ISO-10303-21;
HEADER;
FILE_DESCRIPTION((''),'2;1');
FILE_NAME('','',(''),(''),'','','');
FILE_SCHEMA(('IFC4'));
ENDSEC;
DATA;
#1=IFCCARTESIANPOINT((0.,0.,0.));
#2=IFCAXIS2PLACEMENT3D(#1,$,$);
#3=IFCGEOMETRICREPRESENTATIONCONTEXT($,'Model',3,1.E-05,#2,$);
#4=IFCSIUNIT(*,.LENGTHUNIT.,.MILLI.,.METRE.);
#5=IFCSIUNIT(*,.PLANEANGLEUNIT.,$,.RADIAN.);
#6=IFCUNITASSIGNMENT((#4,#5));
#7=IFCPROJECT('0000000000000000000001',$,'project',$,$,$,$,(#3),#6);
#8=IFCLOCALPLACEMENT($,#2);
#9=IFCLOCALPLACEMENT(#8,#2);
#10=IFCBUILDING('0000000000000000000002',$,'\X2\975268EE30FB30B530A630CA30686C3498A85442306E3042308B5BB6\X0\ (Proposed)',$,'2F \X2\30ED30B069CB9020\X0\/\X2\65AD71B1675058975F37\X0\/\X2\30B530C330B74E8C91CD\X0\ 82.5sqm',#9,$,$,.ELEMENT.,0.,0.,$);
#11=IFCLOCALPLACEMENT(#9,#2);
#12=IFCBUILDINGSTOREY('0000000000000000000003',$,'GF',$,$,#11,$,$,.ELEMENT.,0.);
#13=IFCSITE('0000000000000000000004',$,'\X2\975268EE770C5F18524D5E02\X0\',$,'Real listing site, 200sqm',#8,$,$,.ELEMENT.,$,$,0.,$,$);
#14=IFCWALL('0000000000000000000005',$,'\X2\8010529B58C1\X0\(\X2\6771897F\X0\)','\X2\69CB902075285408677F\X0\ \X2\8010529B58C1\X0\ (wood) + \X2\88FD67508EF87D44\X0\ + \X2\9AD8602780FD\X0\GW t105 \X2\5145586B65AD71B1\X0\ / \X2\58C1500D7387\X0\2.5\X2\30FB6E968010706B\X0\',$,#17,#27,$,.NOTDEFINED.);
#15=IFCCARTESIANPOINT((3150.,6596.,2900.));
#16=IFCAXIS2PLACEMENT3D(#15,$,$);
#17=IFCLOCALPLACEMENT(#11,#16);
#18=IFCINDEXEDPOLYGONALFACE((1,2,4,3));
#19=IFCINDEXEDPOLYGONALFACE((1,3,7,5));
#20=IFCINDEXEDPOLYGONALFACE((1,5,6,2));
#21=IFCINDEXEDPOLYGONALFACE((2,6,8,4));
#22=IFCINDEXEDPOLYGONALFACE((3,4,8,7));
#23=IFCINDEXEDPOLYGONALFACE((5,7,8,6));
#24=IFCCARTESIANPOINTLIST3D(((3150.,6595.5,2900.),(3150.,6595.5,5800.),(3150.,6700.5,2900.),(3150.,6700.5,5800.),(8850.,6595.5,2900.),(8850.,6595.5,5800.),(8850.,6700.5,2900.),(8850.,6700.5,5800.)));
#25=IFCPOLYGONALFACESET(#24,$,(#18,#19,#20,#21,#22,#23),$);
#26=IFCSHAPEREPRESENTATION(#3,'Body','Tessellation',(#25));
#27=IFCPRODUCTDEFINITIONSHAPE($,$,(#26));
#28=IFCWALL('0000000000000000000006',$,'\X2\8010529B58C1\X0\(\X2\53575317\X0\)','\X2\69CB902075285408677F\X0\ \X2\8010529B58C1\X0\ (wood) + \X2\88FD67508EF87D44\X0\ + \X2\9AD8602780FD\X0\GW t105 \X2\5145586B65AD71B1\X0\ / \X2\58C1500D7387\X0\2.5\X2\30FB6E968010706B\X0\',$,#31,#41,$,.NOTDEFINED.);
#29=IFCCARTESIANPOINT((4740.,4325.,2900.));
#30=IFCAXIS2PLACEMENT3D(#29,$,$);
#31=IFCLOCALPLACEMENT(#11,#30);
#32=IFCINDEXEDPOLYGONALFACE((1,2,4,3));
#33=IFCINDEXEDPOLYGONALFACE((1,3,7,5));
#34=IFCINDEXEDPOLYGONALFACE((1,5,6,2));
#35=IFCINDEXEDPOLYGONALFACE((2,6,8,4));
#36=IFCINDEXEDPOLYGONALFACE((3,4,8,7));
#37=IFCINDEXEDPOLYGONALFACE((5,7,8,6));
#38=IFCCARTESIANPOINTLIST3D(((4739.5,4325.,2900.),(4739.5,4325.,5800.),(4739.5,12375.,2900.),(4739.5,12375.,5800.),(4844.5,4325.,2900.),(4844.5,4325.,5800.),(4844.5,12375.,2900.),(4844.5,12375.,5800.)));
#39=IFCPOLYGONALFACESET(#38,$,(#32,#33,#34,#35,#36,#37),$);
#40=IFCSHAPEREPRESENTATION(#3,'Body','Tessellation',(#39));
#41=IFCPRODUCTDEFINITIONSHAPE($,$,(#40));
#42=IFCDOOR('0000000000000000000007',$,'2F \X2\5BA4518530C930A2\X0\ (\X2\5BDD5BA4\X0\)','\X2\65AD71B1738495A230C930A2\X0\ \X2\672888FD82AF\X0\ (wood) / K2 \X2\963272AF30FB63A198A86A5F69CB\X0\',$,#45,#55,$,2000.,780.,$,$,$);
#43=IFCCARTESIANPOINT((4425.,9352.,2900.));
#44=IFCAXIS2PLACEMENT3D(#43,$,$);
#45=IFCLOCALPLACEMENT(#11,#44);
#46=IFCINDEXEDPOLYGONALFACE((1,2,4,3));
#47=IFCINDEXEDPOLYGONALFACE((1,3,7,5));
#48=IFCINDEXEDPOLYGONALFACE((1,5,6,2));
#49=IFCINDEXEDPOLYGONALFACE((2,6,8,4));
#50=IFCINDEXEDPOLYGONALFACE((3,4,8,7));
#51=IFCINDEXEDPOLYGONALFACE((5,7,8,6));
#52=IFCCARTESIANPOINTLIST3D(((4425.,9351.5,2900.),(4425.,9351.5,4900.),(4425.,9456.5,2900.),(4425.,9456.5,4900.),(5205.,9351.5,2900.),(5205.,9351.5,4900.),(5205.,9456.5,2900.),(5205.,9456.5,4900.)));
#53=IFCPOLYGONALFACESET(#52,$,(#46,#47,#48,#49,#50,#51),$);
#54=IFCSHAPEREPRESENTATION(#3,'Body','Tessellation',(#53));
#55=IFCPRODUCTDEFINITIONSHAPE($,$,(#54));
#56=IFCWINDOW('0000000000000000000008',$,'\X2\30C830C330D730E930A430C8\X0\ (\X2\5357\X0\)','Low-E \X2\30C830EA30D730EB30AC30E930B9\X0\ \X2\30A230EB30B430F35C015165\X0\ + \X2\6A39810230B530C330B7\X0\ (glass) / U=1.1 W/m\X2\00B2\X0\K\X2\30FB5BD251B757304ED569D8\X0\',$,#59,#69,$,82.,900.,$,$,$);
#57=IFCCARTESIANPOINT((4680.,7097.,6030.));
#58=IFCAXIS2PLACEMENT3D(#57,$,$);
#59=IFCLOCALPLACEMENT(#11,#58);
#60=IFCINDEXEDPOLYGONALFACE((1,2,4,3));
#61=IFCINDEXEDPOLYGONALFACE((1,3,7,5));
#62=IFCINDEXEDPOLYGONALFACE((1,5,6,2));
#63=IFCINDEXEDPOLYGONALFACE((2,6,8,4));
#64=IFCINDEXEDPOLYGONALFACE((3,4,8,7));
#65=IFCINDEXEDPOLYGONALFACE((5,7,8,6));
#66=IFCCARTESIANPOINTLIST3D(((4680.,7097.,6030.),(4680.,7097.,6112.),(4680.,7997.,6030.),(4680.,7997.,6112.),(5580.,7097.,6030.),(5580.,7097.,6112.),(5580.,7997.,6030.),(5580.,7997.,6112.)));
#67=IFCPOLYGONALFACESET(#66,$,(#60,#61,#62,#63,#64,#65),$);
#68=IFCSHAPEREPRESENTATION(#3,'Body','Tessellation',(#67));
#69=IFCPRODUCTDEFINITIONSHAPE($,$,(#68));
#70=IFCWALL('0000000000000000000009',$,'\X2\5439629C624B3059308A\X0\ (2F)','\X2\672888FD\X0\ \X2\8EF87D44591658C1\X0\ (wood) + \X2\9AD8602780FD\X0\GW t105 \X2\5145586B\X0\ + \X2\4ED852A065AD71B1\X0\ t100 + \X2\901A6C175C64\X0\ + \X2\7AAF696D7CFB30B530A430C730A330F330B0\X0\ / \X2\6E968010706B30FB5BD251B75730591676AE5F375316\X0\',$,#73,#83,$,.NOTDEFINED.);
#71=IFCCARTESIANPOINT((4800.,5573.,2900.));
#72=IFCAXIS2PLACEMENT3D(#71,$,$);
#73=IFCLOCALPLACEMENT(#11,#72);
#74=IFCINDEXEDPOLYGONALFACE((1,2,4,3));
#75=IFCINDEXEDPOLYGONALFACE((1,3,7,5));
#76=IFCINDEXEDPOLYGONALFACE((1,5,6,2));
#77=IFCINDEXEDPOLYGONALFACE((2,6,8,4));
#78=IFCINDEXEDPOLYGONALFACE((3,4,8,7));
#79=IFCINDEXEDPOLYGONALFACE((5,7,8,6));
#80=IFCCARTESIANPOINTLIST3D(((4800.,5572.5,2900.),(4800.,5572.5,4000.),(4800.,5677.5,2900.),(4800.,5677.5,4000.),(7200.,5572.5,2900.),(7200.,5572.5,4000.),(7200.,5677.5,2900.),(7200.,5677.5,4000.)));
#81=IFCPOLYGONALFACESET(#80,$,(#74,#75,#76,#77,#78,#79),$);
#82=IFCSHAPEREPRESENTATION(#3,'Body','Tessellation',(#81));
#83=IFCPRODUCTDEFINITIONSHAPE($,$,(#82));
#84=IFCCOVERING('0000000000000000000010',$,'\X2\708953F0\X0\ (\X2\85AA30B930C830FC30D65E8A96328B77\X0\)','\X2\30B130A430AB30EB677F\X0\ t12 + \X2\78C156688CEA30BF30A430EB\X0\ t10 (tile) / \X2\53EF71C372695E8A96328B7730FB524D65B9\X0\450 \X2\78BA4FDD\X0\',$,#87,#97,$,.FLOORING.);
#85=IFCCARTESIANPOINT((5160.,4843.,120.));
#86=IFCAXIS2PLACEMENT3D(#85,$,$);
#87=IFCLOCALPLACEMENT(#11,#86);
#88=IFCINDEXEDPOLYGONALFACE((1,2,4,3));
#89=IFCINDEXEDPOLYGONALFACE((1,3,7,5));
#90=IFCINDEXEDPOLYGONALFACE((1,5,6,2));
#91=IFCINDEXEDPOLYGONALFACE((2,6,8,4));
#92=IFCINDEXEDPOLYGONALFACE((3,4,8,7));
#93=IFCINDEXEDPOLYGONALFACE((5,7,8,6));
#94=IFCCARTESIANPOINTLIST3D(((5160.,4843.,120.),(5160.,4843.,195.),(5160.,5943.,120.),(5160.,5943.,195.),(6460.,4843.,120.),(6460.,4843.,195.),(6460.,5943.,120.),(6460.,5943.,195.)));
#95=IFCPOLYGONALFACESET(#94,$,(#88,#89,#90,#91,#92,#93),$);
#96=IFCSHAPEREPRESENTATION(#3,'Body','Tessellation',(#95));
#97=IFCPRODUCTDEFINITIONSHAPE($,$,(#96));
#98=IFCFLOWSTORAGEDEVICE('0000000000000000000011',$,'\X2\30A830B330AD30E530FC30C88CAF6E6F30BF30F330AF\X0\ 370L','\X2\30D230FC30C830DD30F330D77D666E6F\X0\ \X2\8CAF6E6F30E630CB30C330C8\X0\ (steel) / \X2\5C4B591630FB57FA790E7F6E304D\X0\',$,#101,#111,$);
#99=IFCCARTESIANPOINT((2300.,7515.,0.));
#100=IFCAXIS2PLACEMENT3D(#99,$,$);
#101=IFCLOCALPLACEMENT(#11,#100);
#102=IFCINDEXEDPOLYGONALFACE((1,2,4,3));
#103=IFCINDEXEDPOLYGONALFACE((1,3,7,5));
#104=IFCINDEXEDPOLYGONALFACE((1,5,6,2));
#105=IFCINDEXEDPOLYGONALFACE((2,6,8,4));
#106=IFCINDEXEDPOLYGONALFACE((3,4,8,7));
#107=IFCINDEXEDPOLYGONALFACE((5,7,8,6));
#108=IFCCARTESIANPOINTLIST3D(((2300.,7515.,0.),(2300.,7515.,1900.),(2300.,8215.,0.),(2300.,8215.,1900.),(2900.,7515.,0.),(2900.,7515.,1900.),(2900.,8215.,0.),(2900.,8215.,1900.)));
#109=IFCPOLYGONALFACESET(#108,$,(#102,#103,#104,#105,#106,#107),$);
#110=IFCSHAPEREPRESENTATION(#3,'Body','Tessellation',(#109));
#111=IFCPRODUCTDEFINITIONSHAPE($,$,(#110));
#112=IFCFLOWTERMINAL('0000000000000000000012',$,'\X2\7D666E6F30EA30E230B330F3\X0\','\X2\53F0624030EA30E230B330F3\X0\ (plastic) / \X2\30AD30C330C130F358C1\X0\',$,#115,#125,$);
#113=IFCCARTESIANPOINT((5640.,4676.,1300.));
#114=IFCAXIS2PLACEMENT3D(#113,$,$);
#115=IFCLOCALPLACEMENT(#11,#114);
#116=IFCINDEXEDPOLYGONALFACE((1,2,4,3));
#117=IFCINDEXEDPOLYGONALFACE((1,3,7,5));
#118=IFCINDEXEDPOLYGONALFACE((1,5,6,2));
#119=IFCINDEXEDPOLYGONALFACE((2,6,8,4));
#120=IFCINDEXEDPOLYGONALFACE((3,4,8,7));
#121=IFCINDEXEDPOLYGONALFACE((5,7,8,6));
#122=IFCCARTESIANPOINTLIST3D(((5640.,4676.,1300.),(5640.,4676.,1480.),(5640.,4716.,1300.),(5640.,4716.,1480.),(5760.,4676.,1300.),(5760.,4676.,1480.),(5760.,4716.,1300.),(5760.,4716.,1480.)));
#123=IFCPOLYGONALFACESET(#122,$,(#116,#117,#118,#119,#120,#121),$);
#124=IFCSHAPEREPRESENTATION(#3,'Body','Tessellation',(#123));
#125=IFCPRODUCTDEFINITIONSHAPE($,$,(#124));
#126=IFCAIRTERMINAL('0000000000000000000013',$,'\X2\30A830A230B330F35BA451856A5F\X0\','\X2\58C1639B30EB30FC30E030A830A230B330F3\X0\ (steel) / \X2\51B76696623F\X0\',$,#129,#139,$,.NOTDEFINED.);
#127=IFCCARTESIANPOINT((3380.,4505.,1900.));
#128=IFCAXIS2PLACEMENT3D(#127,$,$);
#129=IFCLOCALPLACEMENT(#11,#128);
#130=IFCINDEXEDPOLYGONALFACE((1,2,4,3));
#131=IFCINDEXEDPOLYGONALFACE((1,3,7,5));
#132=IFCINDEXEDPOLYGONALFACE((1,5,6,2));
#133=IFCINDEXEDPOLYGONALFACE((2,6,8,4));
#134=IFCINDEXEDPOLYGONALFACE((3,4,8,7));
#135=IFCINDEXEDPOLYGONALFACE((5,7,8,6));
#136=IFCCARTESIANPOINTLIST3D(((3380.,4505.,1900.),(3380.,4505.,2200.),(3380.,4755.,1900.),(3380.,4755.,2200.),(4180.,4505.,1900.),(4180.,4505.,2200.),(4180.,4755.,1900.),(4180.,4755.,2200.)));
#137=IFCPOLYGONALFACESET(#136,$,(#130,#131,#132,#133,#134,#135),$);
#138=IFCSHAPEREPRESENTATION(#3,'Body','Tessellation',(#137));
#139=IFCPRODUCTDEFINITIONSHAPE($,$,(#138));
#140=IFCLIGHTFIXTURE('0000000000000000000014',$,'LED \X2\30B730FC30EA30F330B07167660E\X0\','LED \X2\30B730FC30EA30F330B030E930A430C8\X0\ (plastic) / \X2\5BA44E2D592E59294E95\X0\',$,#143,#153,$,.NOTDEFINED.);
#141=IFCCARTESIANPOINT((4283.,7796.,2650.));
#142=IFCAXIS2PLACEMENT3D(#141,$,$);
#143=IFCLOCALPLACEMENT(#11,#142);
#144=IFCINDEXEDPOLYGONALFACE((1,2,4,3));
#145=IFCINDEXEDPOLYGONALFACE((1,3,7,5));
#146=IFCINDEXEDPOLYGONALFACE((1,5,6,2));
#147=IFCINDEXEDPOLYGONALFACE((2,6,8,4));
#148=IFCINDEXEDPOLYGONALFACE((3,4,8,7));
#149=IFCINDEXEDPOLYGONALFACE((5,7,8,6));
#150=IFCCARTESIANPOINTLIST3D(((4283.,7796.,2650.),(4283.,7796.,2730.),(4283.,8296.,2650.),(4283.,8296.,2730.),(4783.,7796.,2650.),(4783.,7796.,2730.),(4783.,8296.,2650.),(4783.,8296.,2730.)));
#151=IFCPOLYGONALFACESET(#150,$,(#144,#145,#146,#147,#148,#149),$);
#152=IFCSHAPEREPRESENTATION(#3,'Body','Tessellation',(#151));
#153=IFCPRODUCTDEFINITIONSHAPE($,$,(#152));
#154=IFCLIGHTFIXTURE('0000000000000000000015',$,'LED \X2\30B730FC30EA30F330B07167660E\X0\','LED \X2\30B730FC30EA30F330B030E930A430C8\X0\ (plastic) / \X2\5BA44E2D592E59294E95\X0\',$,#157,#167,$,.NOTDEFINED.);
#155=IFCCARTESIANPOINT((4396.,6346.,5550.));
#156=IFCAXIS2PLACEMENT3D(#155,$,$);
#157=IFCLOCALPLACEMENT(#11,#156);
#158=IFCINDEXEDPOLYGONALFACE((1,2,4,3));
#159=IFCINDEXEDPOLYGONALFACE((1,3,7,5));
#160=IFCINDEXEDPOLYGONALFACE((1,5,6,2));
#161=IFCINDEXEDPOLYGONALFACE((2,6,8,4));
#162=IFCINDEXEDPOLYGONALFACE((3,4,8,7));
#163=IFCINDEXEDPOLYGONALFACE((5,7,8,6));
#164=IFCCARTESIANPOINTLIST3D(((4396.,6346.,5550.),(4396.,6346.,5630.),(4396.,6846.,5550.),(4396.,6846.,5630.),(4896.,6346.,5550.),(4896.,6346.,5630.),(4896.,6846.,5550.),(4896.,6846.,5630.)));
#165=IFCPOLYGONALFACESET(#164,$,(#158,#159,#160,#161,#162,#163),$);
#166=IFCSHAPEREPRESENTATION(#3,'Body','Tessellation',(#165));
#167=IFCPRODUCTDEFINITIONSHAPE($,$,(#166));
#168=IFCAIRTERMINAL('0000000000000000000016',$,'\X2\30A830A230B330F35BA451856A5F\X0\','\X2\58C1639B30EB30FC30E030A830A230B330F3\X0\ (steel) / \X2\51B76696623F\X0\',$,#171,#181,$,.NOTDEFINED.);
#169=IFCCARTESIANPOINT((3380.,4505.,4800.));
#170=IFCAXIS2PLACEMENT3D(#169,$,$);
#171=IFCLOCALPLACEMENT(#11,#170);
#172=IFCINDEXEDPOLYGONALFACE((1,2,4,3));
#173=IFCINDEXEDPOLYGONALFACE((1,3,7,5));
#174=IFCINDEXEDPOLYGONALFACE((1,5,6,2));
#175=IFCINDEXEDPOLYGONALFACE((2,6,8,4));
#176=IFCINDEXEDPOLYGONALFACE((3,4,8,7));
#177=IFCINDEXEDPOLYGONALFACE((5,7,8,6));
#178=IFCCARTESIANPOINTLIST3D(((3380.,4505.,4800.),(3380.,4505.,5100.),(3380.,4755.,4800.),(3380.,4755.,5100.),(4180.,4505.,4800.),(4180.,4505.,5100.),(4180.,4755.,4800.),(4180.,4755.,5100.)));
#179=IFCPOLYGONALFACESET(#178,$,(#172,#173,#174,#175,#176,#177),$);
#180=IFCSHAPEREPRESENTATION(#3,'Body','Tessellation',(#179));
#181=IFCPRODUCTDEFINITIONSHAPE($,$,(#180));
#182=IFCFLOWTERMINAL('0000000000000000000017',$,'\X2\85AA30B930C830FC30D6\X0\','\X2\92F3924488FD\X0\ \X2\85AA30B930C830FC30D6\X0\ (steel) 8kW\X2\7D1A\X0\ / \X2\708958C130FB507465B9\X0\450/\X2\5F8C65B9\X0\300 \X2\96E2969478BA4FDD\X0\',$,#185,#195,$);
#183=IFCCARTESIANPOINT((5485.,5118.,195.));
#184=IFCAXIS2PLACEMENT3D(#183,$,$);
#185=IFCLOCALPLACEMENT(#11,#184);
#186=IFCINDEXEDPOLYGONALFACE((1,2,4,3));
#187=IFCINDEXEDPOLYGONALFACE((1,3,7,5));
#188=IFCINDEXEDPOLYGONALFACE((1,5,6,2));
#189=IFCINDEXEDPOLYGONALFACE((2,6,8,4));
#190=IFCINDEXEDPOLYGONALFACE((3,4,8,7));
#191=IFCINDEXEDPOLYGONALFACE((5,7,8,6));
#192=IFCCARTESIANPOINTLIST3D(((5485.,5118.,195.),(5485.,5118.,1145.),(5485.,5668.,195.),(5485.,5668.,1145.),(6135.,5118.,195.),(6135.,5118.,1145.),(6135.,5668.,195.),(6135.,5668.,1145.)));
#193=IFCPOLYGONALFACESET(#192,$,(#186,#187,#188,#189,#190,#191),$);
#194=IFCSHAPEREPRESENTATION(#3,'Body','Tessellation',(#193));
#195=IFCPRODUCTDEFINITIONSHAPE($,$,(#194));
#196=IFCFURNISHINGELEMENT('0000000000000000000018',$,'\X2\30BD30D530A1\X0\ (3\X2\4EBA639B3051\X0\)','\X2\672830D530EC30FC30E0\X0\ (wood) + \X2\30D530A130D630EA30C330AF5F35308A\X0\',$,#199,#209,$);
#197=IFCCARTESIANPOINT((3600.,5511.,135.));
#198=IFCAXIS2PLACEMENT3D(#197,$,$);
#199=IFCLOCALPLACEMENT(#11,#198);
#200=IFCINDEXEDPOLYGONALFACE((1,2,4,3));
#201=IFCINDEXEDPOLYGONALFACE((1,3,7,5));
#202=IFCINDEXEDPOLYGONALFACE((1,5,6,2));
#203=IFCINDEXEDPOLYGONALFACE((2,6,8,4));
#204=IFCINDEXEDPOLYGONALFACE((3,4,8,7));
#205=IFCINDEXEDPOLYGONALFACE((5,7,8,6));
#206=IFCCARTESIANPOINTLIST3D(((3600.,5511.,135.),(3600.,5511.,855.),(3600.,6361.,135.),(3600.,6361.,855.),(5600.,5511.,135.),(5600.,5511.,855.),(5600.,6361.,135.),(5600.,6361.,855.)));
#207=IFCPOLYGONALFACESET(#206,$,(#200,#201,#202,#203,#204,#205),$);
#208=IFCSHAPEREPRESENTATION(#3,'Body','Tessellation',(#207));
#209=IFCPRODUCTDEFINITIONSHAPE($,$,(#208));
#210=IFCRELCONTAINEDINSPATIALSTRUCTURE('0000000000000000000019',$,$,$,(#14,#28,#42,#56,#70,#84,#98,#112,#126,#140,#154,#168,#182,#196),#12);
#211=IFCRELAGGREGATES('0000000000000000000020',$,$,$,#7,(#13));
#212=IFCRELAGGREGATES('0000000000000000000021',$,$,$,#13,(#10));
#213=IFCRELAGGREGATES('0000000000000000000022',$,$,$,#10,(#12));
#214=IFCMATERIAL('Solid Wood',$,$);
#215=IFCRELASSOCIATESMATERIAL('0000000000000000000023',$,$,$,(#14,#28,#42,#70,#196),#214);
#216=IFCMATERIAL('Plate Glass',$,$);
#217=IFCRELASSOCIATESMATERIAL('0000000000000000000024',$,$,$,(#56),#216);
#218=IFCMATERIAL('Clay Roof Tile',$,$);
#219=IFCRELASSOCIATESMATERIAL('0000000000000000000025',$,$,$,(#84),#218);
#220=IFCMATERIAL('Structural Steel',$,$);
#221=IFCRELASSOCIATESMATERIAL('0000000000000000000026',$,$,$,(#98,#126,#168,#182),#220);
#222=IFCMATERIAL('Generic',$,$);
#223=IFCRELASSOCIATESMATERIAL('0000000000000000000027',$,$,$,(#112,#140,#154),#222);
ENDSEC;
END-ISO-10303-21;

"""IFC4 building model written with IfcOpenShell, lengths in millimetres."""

from ifc_helpers import new_model, si_unit, frame, frame_2d, origin, place, context, project, spatial, rectangle, extrude, material, element, fill, save


model = new_model("IFC4")

# Units and contexts
model_context = context("Model", 3, precision=1e-05, world=origin())
ifc_project = project(units=[si_unit("LENGTHUNIT", "METRE", prefix="MILLI"), si_unit("PLANEANGLEUNIT", "RADIAN")], contexts=[model_context])

# Site, building, storey
site_placement = place(None, origin())
site = spatial("IfcSite", under=ifc_project, at=site_placement, Name="青森県弘前市", ObjectType="Real listing site, 200sqm", CompositionType="ELEMENT", RefElevation=0.0)
building_placement = place(site_placement, origin())
building = spatial("IfcBuilding", under=site, at=building_placement, Name="青森・サウナと水風呂のある家 (Proposed)", ObjectType="2F ログ構造/断熱材増強/サッシ二重 82.5sqm", CompositionType="ELEMENT", ElevationOfRefHeight=0.0, ElevationOfTerrain=0.0)
storey_placement = place(building_placement, origin())
storey = spatial("IfcBuildingStorey", under=building, at=storey_placement, Name="GF", CompositionType="ELEMENT", Elevation=0.0)

# Shared definitions
ifc_material_1 = material(Name="Solid Wood")

# Wall
wall_1_placement = place(storey_placement, frame((3150.0, 6596.0, 2900.0)))
element("IfcWall", 1, at=wall_1_placement, inside=storey, material=ifc_material_1, Name="耐力壁(東西)", Description="構造用合板 耐力壁 (wood) + 製材軸組 + 高性能GW t105 充填断熱 / 壁倍率2.5・準耐火", PredefinedType="NOTDEFINED", context=model_context, shape_type="SweptSolid", body=[
    extrude(rectangle(XDim=5700.0, YDim=105.0, at=frame_2d((2850.0, 52.0))), frame((3150.0, 6596.0, 2900.0)), (0.0, 0.0, 1.0), 2900.0),
])

# Wall, opening, door
wall_2_placement = place(storey_placement, frame((4740.0, 4325.0, 2900.0)))
wall_2 = element("IfcWall", 2, at=wall_2_placement, inside=storey, material=ifc_material_1, Name="耐力壁(南北)", Description="構造用合板 耐力壁 (wood) + 製材軸組 + 高性能GW t105 充填断熱 / 壁倍率2.5・準耐火", PredefinedType="NOTDEFINED", context=model_context, shape_type="SweptSolid", body=[
    extrude(rectangle(XDim=105.0, YDim=8050.0, at=frame_2d((52.0, 4025.0))), frame((4740.0, 4325.0, 2900.0)), (0.0, 0.0, 1.0), 2900.0),
])
opening_placement = place(storey_placement, frame((4425.0, 9352.0, 2900.0)))
opening = element("IfcOpeningElement", 3, at=opening_placement, cuts=wall_2, PredefinedType="NOTDEFINED", context=model_context, shape_type="SweptSolid", body=[
    extrude(rectangle(XDim=780.0, YDim=105.0, at=frame_2d((390.0, 52.0))), frame((4425.0, 9352.0, 2900.0)), (0.0, 0.0, 1.0), 2000.0),
])
door_placement = place(storey_placement, frame((4425.0, 9352.0, 2900.0)))
door = element("IfcDoor", 4, at=door_placement, inside=storey, material=ifc_material_1, Name="2F 室内ドア (寝室)", Description="断熱玄関ドア 木製芯 (wood) / K2 防犯・採風機構", OverallHeight=2000.0, OverallWidth=780.0, context=model_context, shape_type="SweptSolid", body=[
    extrude(rectangle(XDim=780.0, YDim=105.0, at=frame_2d((390.0, 52.0))), frame((4425.0, 9352.0, 2900.0)), (0.0, 0.0, 1.0), 2000.0),
])
fill(opening, door)

# Window
ifc_material_2 = material(Name="Plate Glass")
window_placement = place(storey_placement, frame((4680.0, 7097.0, 6030.0)))
element("IfcWindow", 5, at=window_placement, inside=storey, material=ifc_material_2, Name="トップライト (南)", Description="Low-E トリプルガラス アルゴン封入 + 樹脂サッシ (glass) / U=1.1 W/m²K・寒冷地仕様", OverallHeight=82.0, OverallWidth=900.0, context=model_context, shape_type="SweptSolid", body=[
    extrude(rectangle(XDim=900.0, YDim=900.0, at=frame_2d((450.0, 450.0))), frame((4680.0, 7097.0, 6030.0)), (0.0, 0.0, 1.0), 82.0),
])

# Wall
wall_3_placement = place(storey_placement, frame((4800.0, 5573.0, 2900.0)))
element("IfcWall", 6, at=wall_3_placement, inside=storey, material=ifc_material_1, Name="吹抜手すり (2F)", Description="木製 軸組外壁 (wood) + 高性能GW t105 充填 + 付加断熱 t100 + 通気層 + 窯業系サイディング / 準耐火・寒冷地外皮強化", PredefinedType="NOTDEFINED", context=model_context, shape_type="SweptSolid", body=[
    extrude(rectangle(XDim=2400.0, YDim=105.0, at=frame_2d((1200.0, 52.0))), frame((4800.0, 5573.0, 2900.0)), (0.0, 0.0, 1.0), 1100.0),
])

# Covering
ifc_material_3 = material(Name="Clay Roof Tile")
covering_placement = place(storey_placement, frame((5160.0, 4843.0, 120.0)))
element("IfcCovering", 7, at=covering_placement, inside=storey, material=ifc_material_3, Name="炉台 (薪ストーブ床防護)", Description="ケイカル板 t12 + 磁器質タイル t10 (tile) / 可燃物床防護・前方450 確保", PredefinedType="FLOORING", context=model_context, shape_type="SweptSolid", body=[
    extrude(rectangle(XDim=1300.0, YDim=1100.0, at=frame_2d((650.0, 550.0))), frame((5160.0, 4843.0, 120.0)), (0.0, 0.0, 1.0), 75.0),
])

# Flow storage device
ifc_material_4 = material(Name="Structural Steel")
flow_storage_device_placement = place(storey_placement, frame((2300.0, 7515.0, 0.0)))
element("IfcFlowStorageDevice", 8, at=flow_storage_device_placement, inside=storey, material=ifc_material_4, Name="エコキュート貯湯タンク 370L", Description="ヒートポンプ給湯 貯湯ユニット (steel) / 屋外・基礎置き", context=model_context, shape_type="SweptSolid", body=[
    extrude(rectangle(XDim=600.0, YDim=700.0, at=frame_2d((300.0, 350.0))), frame((2300.0, 7515.0, 0.0)), (0.0, 0.0, 1.0), 1900.0),
])

# Flow terminal
ifc_material_5 = material(Name="Generic")
flow_terminal_1_placement = place(storey_placement, frame((5640.0, 4676.0, 1300.0)))
element("IfcFlowTerminal", 9, at=flow_terminal_1_placement, inside=storey, material=ifc_material_5, Name="給湯リモコン", Description="台所リモコン (plastic) / キッチン壁", context=model_context, shape_type="SweptSolid", body=[
    extrude(rectangle(XDim=120.0, YDim=40.0, at=frame_2d((60.0, 20.0))), frame((5640.0, 4676.0, 1300.0)), (0.0, 0.0, 1.0), 180.0),
])

# Air terminal
air_terminal_1_placement = place(storey_placement, frame((3380.0, 4505.0, 1900.0)))
element("IfcAirTerminal", 10, at=air_terminal_1_placement, inside=storey, material=ifc_material_4, Name="エアコン室内機", Description="壁掛ルームエアコン (steel) / 冷暖房", PredefinedType="NOTDEFINED", context=model_context, shape_type="SweptSolid", body=[
    extrude(rectangle(XDim=800.0, YDim=250.0, at=frame_2d((400.0, 125.0))), frame((3380.0, 4505.0, 1900.0)), (0.0, 0.0, 1.0), 300.0),
])

# Light fixtures
light_fixture_1_placement = place(storey_placement, frame((4283.0, 7796.0, 2650.0)))
element("IfcLightFixture", 11, at=light_fixture_1_placement, inside=storey, material=ifc_material_5, Name="LED シーリング照明", Description="LED シーリングライト (plastic) / 室中央天井", PredefinedType="NOTDEFINED", context=model_context, shape_type="SweptSolid", body=[
    extrude(rectangle(XDim=500.0, YDim=500.0, at=frame_2d((250.0, 250.0))), frame((4283.0, 7796.0, 2650.0)), (0.0, 0.0, 1.0), 80.0),
])
light_fixture_2_placement = place(storey_placement, frame((4396.0, 6346.0, 5550.0)))
element("IfcLightFixture", 12, at=light_fixture_2_placement, inside=storey, material=ifc_material_5, Name="LED シーリング照明", Description="LED シーリングライト (plastic) / 室中央天井", PredefinedType="NOTDEFINED", context=model_context, shape_type="SweptSolid", body=[
    extrude(rectangle(XDim=500.0, YDim=500.0, at=frame_2d((250.0, 250.0))), frame((4396.0, 6346.0, 5550.0)), (0.0, 0.0, 1.0), 80.0),
])

# Air terminal
air_terminal_2_placement = place(storey_placement, frame((3380.0, 4505.0, 4800.0)))
element("IfcAirTerminal", 13, at=air_terminal_2_placement, inside=storey, material=ifc_material_4, Name="エアコン室内機", Description="壁掛ルームエアコン (steel) / 冷暖房", PredefinedType="NOTDEFINED", context=model_context, shape_type="SweptSolid", body=[
    extrude(rectangle(XDim=800.0, YDim=250.0, at=frame_2d((400.0, 125.0))), frame((3380.0, 4505.0, 4800.0)), (0.0, 0.0, 1.0), 300.0),
])

# Flow terminal
flow_terminal_2_placement = place(storey_placement, frame((5485.0, 5118.0, 195.0)))
element("IfcFlowTerminal", 14, at=flow_terminal_2_placement, inside=storey, material=ifc_material_4, Name="薪ストーブ", Description="鋳鉄製 薪ストーブ (steel) 8kW級 / 炉壁・側方450/後方300 離隔確保", context=model_context, shape_type="SweptSolid", body=[
    extrude(rectangle(XDim=650.0, YDim=550.0, at=frame_2d((325.0, 275.0))), frame((5485.0, 5118.0, 195.0)), (0.0, 0.0, 1.0), 950.0),
])

# Furnishing element
furnishing_1_placement = place(storey_placement, frame((3600.0, 5511.0, 135.0)))
element("IfcFurnishingElement", 15, at=furnishing_1_placement, inside=storey, material=ifc_material_1, Name="ソファ (3人掛け)", Description="木フレーム (wood) + ファブリック張り", context=model_context, shape_type="SweptSolid", body=[
    extrude(rectangle(XDim=2000.0, YDim=850.0, at=frame_2d((1000.0, 425.0))), frame((3600.0, 5511.0, 135.0)), (0.0, 0.0, 1.0), 720.0),
])

save(model, "model.ifc")
